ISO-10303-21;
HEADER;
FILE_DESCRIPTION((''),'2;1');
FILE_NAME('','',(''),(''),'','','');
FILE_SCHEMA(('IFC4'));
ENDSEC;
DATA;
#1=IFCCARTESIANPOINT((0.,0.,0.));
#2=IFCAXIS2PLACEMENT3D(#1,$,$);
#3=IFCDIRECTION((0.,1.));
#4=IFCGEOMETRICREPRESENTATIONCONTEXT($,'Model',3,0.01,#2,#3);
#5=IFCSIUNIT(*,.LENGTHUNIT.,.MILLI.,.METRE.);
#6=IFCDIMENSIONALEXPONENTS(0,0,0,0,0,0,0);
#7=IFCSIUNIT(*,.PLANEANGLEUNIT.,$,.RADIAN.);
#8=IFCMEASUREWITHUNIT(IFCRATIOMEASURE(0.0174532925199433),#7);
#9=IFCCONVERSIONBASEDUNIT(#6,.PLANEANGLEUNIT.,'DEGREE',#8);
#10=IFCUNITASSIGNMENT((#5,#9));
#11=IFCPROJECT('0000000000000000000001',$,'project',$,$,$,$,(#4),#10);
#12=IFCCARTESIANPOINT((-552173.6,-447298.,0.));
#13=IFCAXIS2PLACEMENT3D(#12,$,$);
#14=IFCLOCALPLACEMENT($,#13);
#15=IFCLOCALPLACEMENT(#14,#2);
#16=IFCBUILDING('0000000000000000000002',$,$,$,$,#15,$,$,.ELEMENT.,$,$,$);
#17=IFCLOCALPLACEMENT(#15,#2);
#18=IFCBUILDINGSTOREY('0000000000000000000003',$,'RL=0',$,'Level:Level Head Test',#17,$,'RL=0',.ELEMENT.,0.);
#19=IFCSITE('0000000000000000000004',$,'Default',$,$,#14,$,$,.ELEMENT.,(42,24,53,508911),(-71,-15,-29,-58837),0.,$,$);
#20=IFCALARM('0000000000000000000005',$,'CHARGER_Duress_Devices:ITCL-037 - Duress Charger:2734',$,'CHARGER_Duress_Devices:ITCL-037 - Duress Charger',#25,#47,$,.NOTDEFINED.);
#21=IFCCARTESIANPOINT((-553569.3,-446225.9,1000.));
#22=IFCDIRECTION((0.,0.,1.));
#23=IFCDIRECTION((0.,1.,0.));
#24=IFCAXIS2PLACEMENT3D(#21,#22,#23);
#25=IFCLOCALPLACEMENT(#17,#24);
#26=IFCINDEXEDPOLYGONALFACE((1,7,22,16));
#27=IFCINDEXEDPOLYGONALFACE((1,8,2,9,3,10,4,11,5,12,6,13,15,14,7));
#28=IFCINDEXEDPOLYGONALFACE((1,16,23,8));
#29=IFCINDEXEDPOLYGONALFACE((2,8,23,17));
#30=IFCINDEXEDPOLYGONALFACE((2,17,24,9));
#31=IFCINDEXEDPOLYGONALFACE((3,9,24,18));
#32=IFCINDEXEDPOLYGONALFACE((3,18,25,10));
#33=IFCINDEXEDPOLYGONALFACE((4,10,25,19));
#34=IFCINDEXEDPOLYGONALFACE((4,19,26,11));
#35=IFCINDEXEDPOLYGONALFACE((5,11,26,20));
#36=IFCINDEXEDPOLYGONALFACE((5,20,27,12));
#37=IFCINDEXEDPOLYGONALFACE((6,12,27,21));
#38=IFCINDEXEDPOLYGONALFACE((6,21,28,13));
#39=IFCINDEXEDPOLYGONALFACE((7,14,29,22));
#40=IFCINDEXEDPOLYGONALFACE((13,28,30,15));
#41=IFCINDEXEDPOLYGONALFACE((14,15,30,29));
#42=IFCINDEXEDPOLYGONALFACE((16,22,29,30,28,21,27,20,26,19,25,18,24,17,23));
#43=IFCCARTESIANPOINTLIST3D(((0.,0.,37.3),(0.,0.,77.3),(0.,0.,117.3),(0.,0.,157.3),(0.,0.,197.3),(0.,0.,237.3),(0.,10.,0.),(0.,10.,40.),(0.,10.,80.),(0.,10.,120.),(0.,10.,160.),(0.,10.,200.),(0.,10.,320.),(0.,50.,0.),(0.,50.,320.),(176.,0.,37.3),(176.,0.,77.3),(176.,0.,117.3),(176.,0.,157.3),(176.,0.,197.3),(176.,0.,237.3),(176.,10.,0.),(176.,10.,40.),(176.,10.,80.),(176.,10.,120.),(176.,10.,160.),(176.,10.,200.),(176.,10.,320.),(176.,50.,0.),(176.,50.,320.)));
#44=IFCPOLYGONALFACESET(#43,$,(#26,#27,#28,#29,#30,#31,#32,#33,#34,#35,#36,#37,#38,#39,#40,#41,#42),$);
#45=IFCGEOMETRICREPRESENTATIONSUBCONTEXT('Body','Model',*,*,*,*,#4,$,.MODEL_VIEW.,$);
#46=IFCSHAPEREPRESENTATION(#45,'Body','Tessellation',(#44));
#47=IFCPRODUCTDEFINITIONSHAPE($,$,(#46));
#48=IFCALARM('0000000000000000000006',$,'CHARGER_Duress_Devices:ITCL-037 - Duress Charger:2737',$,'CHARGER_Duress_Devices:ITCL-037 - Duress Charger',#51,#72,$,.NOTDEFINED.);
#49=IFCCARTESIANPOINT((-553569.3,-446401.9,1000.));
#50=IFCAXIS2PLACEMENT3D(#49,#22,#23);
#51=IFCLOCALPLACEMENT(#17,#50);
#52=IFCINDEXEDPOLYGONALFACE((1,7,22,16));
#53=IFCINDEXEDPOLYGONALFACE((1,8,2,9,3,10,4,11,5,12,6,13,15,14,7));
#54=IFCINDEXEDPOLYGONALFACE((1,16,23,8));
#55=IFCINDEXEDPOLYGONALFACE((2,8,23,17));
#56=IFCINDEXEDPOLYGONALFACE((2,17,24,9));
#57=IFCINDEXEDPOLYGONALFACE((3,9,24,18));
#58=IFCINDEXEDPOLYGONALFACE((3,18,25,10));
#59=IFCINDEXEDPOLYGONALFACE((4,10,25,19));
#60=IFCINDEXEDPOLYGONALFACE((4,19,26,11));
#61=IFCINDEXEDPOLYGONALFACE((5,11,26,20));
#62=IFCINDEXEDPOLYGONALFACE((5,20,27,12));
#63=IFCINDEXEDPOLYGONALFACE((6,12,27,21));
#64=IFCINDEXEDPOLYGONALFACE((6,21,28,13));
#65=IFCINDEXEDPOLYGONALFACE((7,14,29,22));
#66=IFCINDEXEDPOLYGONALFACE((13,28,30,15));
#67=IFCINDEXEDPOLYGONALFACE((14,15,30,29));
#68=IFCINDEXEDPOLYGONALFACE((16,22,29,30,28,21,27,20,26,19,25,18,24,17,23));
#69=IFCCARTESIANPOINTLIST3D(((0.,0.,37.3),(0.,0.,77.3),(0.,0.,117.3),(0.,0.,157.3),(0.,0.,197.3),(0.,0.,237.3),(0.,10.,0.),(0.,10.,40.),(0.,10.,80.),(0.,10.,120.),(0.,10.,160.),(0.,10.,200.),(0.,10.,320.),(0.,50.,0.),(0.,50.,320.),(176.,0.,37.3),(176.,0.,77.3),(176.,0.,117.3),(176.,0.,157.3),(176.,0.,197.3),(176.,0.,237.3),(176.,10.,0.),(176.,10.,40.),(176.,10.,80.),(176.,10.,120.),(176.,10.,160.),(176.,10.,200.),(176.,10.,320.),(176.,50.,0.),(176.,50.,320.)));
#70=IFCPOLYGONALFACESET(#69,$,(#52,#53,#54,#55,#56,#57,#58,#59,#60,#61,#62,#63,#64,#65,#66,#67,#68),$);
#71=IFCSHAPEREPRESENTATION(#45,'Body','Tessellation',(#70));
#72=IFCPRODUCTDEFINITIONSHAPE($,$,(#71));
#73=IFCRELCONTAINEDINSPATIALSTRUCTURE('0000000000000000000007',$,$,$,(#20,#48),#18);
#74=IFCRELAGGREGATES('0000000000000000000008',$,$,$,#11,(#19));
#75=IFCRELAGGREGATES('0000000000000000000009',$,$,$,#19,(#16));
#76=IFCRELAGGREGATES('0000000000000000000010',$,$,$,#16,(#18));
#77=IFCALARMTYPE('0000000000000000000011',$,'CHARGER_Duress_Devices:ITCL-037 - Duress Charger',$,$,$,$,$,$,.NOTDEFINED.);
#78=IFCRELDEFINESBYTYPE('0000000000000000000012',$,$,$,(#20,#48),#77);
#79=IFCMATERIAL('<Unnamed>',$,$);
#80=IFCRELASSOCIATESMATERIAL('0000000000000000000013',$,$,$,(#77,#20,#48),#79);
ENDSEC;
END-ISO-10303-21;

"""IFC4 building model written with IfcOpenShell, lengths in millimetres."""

from ifc_helpers import new_model, entity, si_unit, converted_unit, direction, frame, origin, place, context, subcontext, project, spatial, indexed_curve, outline, extrude, source, transform, mapped, material, type_object, type_shapes, element, save


model = new_model("IFC4")

# Units and contexts
model_context = context("Model", 3, precision=0.01, world=origin(), true_north=direction((0.0, 1.0)))
body_context = subcontext(model_context, "Body", "Model", "MODEL_VIEW")
ifc_project = project(units=[si_unit("LENGTHUNIT", "METRE", prefix="MILLI"), converted_unit("PLANEANGLEUNIT", "DEGREE", entity("IfcRatioMeasure", 0.0174532925199433), si_unit("PLANEANGLEUNIT", "RADIAN"), dimensions=[0, 0, 0, 0, 0, 0, 0])], contexts=[model_context])

# Site, building, storey
site_placement = place(None, frame((-552173.6, -447298.0, 0.0)))
site = spatial("IfcSite", under=ifc_project, at=site_placement, Name="Default", CompositionType="ELEMENT", RefLatitude=(42, 24, 53, 508911), RefLongitude=(-71, -15, -29, -58837), RefElevation=0.0)
building_placement = place(site_placement, origin())
building = spatial("IfcBuilding", under=site, at=building_placement, CompositionType="ELEMENT")
storey_placement = place(building_placement, origin())
storey = spatial("IfcBuildingStorey", under=building, at=storey_placement, Name="RL=0", ObjectType="Level:Level Head Test", LongName="RL=0", CompositionType="ELEMENT", Elevation=0.0)

# Shared definitions
ifc_material_1 = material(Name="<Unnamed>")

# Alarms
alarm_type = type_object("IfcAlarmType", Name="CHARGER_Duress_Devices:ITCL-037 - Duress Charger", PredefinedType="NOTDEFINED", material=ifc_material_1)
shared_shape_1 = source(origin(), body_context, "Body", "SweptSolid", [
    extrude(outline(indexed_curve([(-38.7, -182.4), (1.3, -182.4), (11.3, -99.7), (1.3, -62.4), (11.3, -59.7), (1.3, -22.4), (11.3, -19.7), (1.3, 17.6), (11.3, 20.3), (1.3, 57.6), (11.3, 60.3), (1.3, 97.6), (11.3, 100.3), (1.3, 137.6), (-38.7, 137.6), (-38.7, -182.4)], self_intersect=False)), frame((0.0, 11.3, 137.6), z_axis=(1.0, 0.0, 0.0), x_axis=(0.0, -1.0, 0.0)), (0.0, 0.0, 1.0), 176.0),
])
type_shapes(alarm_type, [shared_shape_1])
for number, where, z_axis, x_axis, name in (
    (1, (-553569.3, -446225.9, 1000.0), (0.0, 0.0, 1.0), (0.0, 1.0, 0.0), "CHARGER_Duress_Devices:ITCL-037 - Duress Charger:2734"),
    (2, (-553569.3, -446401.9, 1000.0), (0.0, 0.0, 1.0), (0.0, 1.0, 0.0), "CHARGER_Duress_Devices:ITCL-037 - Duress Charger:2737"),
):
    element("IfcAlarm", number, at=place(storey_placement, frame(where, z_axis=z_axis, x_axis=x_axis)), inside=storey, type_object=alarm_type, material=ifc_material_1, Name=name, ObjectType="CHARGER_Duress_Devices:ITCL-037 - Duress Charger", PredefinedType="NOTDEFINED", context=body_context, shape_type="MappedRepresentation", body=[
        mapped(shared_shape_1, transform((0.0, 0.0, 0.0), scale=1.0)),
    ])

save(model, "model.ifc")
